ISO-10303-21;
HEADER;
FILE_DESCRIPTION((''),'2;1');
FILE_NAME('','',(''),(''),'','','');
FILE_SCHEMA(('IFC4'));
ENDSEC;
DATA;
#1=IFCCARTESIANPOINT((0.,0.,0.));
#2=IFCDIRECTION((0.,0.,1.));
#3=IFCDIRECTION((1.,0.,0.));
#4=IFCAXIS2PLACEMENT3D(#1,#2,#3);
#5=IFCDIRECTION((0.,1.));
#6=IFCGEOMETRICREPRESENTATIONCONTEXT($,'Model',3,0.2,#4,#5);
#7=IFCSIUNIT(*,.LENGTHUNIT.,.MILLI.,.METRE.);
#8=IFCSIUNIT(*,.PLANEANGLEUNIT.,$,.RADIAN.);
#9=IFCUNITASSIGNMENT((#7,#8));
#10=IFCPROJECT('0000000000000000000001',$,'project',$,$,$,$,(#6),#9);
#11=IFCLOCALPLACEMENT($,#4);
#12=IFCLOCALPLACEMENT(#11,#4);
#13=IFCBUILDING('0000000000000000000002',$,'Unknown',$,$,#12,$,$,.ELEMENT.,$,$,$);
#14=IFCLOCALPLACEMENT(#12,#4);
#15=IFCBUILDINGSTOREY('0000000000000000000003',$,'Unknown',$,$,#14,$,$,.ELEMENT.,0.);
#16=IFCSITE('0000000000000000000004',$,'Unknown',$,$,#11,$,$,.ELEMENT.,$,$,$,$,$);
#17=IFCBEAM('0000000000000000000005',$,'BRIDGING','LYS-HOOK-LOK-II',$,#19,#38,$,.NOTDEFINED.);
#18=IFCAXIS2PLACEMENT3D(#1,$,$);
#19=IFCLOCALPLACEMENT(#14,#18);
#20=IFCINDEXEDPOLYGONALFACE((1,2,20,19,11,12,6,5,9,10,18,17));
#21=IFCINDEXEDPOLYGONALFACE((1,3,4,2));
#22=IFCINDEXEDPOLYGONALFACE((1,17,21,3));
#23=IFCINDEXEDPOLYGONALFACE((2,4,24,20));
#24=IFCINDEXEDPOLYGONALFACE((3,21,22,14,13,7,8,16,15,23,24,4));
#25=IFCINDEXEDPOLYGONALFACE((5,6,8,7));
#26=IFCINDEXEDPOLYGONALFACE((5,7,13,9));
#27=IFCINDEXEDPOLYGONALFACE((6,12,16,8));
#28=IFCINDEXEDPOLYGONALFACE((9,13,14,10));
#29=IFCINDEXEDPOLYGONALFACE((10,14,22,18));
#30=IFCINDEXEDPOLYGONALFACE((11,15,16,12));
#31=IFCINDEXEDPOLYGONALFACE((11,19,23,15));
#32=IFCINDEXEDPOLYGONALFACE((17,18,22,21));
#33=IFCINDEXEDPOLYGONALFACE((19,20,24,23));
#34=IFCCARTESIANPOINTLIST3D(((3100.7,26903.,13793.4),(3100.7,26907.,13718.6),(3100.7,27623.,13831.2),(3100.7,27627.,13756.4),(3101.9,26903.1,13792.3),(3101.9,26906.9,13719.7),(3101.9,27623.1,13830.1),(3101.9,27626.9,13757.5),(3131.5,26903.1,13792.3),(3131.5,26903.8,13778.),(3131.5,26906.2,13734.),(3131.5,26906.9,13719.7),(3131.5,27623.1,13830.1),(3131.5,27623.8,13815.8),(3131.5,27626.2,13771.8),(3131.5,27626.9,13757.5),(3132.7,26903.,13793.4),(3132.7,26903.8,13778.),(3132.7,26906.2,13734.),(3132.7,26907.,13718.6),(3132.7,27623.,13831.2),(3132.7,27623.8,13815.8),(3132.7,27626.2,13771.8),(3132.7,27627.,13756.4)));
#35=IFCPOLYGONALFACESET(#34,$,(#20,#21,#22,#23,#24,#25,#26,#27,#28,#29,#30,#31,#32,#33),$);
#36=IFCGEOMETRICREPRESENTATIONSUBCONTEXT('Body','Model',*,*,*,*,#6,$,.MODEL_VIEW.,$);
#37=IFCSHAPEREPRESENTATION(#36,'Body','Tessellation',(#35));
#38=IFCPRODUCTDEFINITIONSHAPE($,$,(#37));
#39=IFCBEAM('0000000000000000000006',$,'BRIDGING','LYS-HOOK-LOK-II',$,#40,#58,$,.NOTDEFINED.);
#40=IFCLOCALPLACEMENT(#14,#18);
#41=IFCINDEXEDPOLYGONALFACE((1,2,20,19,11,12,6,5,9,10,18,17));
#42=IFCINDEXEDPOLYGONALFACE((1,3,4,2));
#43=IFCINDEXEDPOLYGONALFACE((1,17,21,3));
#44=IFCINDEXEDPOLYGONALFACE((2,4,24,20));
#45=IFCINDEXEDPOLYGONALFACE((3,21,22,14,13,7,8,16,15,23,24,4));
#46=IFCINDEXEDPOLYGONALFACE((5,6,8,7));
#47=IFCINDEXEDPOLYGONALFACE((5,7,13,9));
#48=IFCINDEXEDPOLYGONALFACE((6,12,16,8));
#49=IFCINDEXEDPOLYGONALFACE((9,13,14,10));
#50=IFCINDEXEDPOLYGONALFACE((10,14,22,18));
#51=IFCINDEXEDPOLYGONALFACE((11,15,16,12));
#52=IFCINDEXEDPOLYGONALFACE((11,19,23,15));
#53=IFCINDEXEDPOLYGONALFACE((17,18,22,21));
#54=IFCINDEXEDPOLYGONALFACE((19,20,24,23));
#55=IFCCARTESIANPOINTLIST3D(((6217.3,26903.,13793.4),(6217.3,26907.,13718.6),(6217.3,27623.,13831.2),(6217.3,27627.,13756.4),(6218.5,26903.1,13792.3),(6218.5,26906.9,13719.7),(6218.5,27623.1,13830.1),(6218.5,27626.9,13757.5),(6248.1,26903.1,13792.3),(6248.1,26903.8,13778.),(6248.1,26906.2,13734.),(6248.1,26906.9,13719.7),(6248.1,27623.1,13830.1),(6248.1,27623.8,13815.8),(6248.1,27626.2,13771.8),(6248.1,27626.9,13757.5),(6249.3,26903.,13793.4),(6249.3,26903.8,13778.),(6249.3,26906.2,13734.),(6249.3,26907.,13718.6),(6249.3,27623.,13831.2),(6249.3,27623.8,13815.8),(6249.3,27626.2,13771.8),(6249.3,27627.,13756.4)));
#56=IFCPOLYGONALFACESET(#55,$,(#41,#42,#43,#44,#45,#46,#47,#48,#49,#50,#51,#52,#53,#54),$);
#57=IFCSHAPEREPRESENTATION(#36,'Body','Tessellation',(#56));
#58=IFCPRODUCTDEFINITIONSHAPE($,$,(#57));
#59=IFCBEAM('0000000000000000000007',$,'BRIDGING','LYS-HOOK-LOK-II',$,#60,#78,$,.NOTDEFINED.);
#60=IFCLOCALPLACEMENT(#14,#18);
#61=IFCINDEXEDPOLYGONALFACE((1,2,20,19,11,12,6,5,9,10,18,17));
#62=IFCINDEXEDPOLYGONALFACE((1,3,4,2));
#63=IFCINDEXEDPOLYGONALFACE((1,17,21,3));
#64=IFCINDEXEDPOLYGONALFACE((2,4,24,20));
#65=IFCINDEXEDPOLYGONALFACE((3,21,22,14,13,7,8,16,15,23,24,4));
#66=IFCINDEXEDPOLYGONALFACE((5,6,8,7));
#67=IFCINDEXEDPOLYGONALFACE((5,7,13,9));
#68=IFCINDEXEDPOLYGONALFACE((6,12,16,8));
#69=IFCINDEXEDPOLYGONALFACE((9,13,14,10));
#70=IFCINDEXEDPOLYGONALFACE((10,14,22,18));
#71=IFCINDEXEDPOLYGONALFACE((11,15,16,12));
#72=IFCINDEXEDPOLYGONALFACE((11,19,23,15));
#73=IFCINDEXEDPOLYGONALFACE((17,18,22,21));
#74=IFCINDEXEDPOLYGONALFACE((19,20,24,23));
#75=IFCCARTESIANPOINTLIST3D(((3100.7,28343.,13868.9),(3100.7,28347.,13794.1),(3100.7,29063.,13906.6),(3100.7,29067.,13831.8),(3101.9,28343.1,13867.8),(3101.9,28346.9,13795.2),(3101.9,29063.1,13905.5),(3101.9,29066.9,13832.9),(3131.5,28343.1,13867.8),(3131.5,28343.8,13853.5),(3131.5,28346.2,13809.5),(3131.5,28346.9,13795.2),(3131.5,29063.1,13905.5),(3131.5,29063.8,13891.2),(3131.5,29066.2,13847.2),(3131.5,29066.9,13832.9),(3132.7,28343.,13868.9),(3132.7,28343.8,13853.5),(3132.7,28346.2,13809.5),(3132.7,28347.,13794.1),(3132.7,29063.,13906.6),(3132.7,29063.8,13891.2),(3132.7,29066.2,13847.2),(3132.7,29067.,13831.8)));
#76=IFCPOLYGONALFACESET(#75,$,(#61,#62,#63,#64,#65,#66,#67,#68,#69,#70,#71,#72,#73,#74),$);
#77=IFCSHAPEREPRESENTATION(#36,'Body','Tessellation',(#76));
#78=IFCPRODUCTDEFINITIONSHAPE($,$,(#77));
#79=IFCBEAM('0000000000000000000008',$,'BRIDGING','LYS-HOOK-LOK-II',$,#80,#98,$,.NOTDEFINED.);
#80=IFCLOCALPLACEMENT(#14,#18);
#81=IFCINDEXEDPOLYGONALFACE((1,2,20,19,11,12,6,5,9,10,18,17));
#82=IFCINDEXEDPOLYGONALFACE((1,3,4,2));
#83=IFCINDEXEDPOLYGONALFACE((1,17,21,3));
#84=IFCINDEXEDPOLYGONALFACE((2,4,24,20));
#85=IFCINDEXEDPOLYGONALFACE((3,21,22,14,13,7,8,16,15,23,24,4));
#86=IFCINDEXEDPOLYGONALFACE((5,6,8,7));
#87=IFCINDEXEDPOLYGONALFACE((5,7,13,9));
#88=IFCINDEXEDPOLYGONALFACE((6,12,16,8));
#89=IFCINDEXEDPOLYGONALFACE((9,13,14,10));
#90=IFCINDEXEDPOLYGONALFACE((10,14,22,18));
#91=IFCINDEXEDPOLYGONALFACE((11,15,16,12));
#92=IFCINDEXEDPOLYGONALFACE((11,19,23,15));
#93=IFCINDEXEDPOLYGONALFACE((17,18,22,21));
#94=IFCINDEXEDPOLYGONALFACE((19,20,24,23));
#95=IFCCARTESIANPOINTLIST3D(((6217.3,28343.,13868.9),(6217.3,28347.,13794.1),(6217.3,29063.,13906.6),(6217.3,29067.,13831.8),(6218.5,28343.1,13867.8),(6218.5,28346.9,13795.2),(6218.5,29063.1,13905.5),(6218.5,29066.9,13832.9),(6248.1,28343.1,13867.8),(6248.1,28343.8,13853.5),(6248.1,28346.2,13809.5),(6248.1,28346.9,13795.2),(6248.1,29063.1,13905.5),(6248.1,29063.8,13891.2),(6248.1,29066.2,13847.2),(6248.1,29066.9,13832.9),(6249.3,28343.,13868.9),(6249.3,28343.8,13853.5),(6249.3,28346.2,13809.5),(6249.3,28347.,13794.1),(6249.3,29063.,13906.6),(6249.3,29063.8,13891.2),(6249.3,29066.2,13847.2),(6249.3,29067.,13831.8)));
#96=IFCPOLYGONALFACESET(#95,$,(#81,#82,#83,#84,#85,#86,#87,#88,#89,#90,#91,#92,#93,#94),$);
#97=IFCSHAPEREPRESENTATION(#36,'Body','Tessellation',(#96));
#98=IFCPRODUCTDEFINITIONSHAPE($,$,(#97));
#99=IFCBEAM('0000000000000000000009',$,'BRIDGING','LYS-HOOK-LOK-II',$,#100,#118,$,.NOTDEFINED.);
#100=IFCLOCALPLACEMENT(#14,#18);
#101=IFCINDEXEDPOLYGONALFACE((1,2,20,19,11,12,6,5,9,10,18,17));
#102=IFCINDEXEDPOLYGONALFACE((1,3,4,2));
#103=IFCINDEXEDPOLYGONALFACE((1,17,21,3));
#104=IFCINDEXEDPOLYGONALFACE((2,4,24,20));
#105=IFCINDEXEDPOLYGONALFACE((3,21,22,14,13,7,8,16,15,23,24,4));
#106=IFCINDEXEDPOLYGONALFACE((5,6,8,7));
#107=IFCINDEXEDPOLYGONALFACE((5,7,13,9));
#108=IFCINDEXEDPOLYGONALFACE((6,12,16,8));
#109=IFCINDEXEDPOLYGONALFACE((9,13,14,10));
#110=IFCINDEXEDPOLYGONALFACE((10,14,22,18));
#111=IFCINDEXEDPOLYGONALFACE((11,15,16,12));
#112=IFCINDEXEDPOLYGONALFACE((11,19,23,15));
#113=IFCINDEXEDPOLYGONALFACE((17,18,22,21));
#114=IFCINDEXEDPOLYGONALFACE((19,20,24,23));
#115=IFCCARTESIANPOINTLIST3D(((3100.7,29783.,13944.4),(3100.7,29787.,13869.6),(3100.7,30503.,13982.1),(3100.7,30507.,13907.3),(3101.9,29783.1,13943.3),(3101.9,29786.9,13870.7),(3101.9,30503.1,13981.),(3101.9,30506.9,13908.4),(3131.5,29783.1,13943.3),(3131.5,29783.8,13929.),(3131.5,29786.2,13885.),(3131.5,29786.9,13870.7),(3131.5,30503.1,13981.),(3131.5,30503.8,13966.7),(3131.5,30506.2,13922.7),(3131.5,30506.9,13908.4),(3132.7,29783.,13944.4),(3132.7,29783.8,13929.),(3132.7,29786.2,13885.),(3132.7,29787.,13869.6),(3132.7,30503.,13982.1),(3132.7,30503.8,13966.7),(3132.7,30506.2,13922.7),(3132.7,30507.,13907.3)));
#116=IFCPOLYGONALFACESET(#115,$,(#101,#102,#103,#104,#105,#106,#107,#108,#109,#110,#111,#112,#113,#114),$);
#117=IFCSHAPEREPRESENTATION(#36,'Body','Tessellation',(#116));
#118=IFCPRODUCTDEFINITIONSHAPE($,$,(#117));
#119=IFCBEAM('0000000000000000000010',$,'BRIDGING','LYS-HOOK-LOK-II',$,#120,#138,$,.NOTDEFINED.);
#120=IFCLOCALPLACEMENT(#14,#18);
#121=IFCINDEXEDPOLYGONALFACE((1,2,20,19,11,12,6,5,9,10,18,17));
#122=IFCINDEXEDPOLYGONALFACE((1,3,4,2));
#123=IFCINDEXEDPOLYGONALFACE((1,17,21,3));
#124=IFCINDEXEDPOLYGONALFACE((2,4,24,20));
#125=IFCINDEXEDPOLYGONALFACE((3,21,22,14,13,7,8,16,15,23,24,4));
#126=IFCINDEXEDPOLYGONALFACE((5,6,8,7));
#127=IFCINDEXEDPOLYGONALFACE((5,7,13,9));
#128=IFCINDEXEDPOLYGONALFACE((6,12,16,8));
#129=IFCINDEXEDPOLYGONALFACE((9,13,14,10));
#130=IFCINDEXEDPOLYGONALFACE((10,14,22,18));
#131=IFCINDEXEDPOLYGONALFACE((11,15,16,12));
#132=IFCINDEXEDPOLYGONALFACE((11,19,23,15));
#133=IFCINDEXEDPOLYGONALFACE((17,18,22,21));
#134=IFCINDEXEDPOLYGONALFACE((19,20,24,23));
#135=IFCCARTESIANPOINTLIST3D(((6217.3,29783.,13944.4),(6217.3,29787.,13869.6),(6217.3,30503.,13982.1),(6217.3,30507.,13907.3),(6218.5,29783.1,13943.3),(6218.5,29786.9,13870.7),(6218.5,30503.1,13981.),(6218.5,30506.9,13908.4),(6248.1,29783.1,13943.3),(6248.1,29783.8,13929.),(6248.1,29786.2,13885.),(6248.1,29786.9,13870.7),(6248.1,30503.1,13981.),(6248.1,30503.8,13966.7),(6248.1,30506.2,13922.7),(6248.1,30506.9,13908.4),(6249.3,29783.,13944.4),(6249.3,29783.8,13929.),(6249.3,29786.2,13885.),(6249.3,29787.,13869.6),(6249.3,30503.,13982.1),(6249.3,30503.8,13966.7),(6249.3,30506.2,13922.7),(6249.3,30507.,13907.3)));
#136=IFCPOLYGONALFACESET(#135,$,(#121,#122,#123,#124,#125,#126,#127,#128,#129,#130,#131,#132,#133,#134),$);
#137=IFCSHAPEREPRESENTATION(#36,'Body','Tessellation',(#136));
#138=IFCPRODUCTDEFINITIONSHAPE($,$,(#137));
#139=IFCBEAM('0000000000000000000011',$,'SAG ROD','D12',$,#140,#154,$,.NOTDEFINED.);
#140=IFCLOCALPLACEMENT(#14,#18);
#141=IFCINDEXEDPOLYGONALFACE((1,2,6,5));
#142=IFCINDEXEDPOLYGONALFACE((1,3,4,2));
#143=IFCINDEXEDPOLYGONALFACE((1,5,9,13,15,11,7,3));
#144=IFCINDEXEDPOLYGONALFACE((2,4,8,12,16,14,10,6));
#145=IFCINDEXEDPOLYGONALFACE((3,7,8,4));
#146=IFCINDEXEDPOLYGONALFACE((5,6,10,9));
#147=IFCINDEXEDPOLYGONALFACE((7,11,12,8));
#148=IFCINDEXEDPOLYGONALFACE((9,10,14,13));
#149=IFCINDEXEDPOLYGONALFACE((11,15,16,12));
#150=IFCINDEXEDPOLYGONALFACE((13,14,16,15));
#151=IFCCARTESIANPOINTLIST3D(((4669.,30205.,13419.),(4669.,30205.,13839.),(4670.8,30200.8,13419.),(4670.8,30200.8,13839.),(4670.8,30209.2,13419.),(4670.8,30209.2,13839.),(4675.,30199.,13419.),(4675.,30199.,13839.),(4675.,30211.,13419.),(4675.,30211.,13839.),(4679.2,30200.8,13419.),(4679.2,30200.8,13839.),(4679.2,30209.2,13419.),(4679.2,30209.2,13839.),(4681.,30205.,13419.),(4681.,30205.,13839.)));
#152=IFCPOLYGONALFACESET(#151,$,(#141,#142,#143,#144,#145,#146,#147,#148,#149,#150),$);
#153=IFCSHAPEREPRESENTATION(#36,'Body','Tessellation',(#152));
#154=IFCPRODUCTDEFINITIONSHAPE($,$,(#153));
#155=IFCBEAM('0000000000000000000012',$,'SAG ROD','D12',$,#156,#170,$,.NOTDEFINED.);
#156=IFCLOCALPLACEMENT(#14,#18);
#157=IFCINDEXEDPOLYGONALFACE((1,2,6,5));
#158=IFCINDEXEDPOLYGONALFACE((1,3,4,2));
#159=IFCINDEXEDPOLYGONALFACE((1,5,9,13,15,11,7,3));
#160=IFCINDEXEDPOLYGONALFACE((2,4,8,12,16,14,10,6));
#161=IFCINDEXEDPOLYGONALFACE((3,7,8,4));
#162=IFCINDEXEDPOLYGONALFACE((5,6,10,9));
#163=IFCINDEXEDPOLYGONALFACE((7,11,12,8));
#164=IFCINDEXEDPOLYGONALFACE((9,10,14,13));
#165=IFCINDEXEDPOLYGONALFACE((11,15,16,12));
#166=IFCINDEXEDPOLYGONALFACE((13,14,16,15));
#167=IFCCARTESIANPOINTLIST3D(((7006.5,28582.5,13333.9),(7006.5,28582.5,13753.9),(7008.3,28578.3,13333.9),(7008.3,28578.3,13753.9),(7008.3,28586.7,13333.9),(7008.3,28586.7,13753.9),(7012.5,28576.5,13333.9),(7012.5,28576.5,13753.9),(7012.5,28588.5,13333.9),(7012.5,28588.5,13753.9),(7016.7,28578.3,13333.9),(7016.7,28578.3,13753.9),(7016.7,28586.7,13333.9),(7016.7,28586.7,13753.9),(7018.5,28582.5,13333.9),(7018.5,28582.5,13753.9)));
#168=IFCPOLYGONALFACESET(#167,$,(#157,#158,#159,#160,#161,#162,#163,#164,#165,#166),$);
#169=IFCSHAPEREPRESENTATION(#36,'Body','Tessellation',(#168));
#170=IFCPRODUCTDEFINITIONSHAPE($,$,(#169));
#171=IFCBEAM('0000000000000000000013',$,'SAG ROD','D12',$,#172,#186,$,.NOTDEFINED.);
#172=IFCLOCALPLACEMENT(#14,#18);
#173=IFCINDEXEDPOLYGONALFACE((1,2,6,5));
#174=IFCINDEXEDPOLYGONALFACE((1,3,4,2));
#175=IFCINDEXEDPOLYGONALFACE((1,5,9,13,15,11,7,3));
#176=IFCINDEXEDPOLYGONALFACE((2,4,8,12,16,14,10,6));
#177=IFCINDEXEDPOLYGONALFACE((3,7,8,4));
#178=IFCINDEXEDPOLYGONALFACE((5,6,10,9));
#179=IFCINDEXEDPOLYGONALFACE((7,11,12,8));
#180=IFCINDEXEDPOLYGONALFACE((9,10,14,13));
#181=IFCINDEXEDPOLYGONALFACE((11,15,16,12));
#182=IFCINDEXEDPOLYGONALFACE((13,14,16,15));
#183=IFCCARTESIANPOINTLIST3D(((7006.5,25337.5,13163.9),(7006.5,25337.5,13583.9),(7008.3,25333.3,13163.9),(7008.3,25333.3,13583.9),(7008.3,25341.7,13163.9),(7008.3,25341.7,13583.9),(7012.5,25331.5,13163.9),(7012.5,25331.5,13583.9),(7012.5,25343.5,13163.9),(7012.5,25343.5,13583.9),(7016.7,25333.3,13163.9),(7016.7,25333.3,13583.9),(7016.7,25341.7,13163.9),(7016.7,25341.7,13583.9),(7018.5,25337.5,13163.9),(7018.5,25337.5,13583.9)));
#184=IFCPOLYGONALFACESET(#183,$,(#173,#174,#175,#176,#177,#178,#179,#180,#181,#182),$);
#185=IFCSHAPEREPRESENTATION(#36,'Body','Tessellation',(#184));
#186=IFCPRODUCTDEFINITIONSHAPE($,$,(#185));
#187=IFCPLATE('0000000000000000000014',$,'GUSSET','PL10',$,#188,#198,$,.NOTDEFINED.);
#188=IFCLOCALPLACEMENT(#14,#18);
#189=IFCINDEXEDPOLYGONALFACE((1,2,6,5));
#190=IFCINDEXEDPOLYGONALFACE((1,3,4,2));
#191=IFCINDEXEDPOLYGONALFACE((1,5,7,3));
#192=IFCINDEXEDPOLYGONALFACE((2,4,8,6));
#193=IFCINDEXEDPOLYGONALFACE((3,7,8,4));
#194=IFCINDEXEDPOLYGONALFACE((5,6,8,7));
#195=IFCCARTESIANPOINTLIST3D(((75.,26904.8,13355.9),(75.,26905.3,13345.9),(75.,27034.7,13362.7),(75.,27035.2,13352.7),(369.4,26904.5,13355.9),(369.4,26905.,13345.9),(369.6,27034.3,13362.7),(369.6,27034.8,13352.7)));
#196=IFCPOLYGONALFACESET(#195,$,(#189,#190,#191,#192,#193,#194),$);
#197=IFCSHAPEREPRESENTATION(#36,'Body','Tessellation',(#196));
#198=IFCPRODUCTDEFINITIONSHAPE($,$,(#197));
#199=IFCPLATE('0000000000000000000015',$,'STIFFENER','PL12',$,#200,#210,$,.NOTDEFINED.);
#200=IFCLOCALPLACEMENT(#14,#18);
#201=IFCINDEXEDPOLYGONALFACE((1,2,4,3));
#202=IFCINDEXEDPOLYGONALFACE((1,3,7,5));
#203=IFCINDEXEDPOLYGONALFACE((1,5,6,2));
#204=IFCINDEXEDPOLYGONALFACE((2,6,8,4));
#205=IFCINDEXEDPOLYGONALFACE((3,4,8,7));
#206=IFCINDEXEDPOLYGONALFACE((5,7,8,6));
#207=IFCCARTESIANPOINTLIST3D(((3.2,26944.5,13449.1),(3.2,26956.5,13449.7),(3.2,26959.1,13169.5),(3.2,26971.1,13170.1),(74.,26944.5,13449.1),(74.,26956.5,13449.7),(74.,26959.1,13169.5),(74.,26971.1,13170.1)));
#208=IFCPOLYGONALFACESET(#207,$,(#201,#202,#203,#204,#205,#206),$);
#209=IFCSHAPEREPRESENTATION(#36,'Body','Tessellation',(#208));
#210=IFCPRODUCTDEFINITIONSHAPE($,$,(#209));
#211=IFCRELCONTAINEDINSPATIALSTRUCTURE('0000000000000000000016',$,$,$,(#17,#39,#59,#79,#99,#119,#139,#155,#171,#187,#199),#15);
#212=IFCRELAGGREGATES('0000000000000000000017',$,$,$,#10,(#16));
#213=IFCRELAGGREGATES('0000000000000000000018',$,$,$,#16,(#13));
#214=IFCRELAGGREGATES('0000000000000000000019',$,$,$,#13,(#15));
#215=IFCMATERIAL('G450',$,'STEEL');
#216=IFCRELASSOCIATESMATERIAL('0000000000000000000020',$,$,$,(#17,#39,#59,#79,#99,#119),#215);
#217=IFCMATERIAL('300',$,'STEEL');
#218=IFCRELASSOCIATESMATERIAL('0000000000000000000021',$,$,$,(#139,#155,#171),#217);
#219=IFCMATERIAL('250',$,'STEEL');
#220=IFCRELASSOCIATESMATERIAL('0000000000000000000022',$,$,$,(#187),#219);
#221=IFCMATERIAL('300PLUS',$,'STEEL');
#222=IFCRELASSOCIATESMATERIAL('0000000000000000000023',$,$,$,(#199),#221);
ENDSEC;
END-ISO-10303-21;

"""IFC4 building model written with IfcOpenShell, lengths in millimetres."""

from ifc_helpers import new_model, si_unit, direction, frame, origin_with_axes, place, context, subcontext, project, spatial, line, indexed_curve, outline, extrude, material, element, save


model = new_model("IFC4")

# Units and contexts
model_context = context("Model", 3, precision=0.2, world=origin_with_axes(), true_north=direction((0.0, 1.0)))
body_context = subcontext(model_context, "Body", "Model", "MODEL_VIEW")
ifc_project = project(units=[si_unit("LENGTHUNIT", "METRE", prefix="MILLI"), si_unit("PLANEANGLEUNIT", "RADIAN")], contexts=[model_context])

# Site, building, storey
site_placement = place(None, origin_with_axes())
site = spatial("IfcSite", under=ifc_project, at=site_placement, Name="Unknown", CompositionType="ELEMENT")
building_placement = place(site_placement, origin_with_axes())
building = spatial("IfcBuilding", under=site, at=building_placement, Name="Unknown", CompositionType="ELEMENT")
storey_placement = place(building_placement, origin_with_axes())
storey = spatial("IfcBuildingStorey", under=building, at=storey_placement, Name="Unknown", CompositionType="ELEMENT", Elevation=0.0)

# Beams
ifc_material_1 = material(Name="300PLUS", Category="STEEL")
ifc_material_2 = material(Name="G450", Category="STEEL")
for number, where, z_axis, x_axis, name in (
    (1, (3116.7, 26905.0, 13756.0), (1.0, 0.0, 0.0), (0.0, 0.998625, 0.052428), "BRIDGING"),
    (2, (6233.3, 26905.0, 13756.0), (1.0, 0.0, 0.0), (0.0, 0.998625, 0.052428), "BRIDGING"),
):
    element("IfcBeam", number, at=place(storey_placement, frame(where, z_axis=z_axis, x_axis=x_axis)), inside=storey, material=ifc_material_2, Name=name, Description="LYS-HOOK-LOK-II", PredefinedType="NOTDEFINED", context=body_context, shape_type="SolidModel", body=[
        extrude(outline(indexed_curve([(16.0, -37.5), (16.0, -22.0), (14.8, -22.0), (14.8, -36.3), (-14.8, -36.3), (-14.8, 36.3), (14.8, 36.3), (14.8, 22.0), (16.0, 22.0), (16.0, 37.5), (-16.0, 37.5), (-16.0, -37.5)], segments=[line(1, 2, 3, 4, 5, 6, 7, 8, 9, 10, 11, 12, 1)])), frame((0.0, 0.0, 0.0), z_axis=(-1.0, 0.0, 0.0), x_axis=(0.0, 0.0, 1.0)), (0.0, 0.0, -1.0), 721.0),
    ])
for number, where, z_axis, x_axis, name in (
    (3, (3116.7, 28345.0, 13831.5), (1.0, 0.0, 0.0), (0.0, 0.998632, 0.052289), "BRIDGING"),
    (4, (6233.3, 28345.0, 13831.5), (1.0, 0.0, 0.0), (0.0, 0.998632, 0.052289), "BRIDGING"),
    (5, (3116.7, 29785.0, 13907.0), (1.0, 0.0, 0.0), (0.0, 0.998632, 0.052289), "BRIDGING"),
    (6, (6233.3, 29785.0, 13907.0), (1.0, 0.0, 0.0), (0.0, 0.998632, 0.052289), "BRIDGING"),
):
    element("IfcBeam", number, at=place(storey_placement, frame(where, z_axis=z_axis, x_axis=x_axis)), inside=storey, material=ifc_material_2, Name=name, Description="LYS-HOOK-LOK-II", PredefinedType="NOTDEFINED", context=body_context, shape_type="SolidModel", body=[
        extrude(outline(indexed_curve([(16.0, -37.5), (16.0, -22.0), (14.8, -22.0), (14.8, -36.3), (-14.8, -36.3), (-14.8, 36.3), (14.8, 36.3), (14.8, 22.0), (16.0, 22.0), (16.0, 37.5), (-16.0, 37.5), (-16.0, -37.5)], segments=[line(1, 2, 3, 4, 5, 6, 7, 8, 9, 10, 11, 12, 1)])), frame((0.0, 0.0, 0.0), z_axis=(-1.0, 0.0, 0.0), x_axis=(0.0, 0.0, 1.0)), (0.0, 0.0, -1.0), 721.0),
    ])
ifc_material_3 = material(Name="300", Category="STEEL")
for number, where, z_axis, x_axis, name in (
    (7, (4675.0, 30205.0, 13839.0), (1.0, 0.0, 0.0), (0.0, 0.0, -1.0), "SAG ROD"),
    (8, (7012.5, 28582.5, 13753.9), (1.0, 0.0, 0.0), (0.0, 0.0, -1.0), "SAG ROD"),
    (9, (7012.5, 25337.5, 13583.9), (1.0, 0.0, 0.0), (0.0, 0.0, -1.0), "SAG ROD"),
):
    element("IfcBeam", number, at=place(storey_placement, frame(where, z_axis=z_axis, x_axis=x_axis)), inside=storey, material=ifc_material_3, Name=name, Description="D12", PredefinedType="NOTDEFINED", context=body_context, shape_type="SolidModel", body=[
        extrude(outline(indexed_curve([(6.0, 0.0), (4.2, 4.2), (0.0, 6.0), (-4.2, 4.2), (-6.0, 0.0), (-4.2, -4.2), (0.0, -6.0), (4.2, -4.2)], segments=[line(1, 2, 3, 4, 5, 6, 7, 8, 1)])), frame((0.0, 0.0, 0.0), z_axis=(-1.0, 0.0, 0.0), x_axis=(0.0, 0.0, 1.0)), (0.0, 0.0, -1.0), 420.0),
    ])

# Plates
ifc_material_4 = material(Name="250", Category="STEEL")
plate_1_placement = place(storey_placement, frame((75.0, 26905.0, 13350.9), z_axis=(-0.000053, -0.052276, 0.998633), x_axis=(0.999999, -0.001019, 0.0)))
element("IfcPlate", 10, at=plate_1_placement, inside=storey, material=ifc_material_4, Name="GUSSET", Description="PL10", PredefinedType="NOTDEFINED", context=body_context, shape_type="SolidModel", body=[
    extrude(outline(indexed_curve([(0.0, 0.0), (294.4, 0.0), (294.5, 130.0), (-0.1, 130.1)], segments=[line(1, 2, 3, 4, 1)])), frame((0.0, 0.0, 5.0), z_axis=(0.0, 0.0, 1.0), x_axis=(1.0, 0.0, 0.0)), (0.0, 0.0, -1.0), 10.0),
])
plate_2_placement = place(storey_placement, frame((3.2, 26965.1, 13169.8), z_axis=(0.0, 0.998639, 0.052146), x_axis=(0.0, -0.052146, 0.998639)))
element("IfcPlate", 11, at=plate_2_placement, inside=storey, material=ifc_material_1, Name="STIFFENER", Description="PL12", PredefinedType="NOTDEFINED", context=body_context, shape_type="SolidModel", body=[
    extrude(outline(indexed_curve([(0.0, 0.0), (280.0, 0.0), (280.0, 70.8), (0.0, 70.8)], segments=[line(1, 2, 3, 4, 1)])), frame((0.0, 0.0, 6.0), z_axis=(0.0, 0.0, 1.0), x_axis=(1.0, 0.0, 0.0)), (0.0, 0.0, -1.0), 12.0),
])

save(model, "model.ifc")
